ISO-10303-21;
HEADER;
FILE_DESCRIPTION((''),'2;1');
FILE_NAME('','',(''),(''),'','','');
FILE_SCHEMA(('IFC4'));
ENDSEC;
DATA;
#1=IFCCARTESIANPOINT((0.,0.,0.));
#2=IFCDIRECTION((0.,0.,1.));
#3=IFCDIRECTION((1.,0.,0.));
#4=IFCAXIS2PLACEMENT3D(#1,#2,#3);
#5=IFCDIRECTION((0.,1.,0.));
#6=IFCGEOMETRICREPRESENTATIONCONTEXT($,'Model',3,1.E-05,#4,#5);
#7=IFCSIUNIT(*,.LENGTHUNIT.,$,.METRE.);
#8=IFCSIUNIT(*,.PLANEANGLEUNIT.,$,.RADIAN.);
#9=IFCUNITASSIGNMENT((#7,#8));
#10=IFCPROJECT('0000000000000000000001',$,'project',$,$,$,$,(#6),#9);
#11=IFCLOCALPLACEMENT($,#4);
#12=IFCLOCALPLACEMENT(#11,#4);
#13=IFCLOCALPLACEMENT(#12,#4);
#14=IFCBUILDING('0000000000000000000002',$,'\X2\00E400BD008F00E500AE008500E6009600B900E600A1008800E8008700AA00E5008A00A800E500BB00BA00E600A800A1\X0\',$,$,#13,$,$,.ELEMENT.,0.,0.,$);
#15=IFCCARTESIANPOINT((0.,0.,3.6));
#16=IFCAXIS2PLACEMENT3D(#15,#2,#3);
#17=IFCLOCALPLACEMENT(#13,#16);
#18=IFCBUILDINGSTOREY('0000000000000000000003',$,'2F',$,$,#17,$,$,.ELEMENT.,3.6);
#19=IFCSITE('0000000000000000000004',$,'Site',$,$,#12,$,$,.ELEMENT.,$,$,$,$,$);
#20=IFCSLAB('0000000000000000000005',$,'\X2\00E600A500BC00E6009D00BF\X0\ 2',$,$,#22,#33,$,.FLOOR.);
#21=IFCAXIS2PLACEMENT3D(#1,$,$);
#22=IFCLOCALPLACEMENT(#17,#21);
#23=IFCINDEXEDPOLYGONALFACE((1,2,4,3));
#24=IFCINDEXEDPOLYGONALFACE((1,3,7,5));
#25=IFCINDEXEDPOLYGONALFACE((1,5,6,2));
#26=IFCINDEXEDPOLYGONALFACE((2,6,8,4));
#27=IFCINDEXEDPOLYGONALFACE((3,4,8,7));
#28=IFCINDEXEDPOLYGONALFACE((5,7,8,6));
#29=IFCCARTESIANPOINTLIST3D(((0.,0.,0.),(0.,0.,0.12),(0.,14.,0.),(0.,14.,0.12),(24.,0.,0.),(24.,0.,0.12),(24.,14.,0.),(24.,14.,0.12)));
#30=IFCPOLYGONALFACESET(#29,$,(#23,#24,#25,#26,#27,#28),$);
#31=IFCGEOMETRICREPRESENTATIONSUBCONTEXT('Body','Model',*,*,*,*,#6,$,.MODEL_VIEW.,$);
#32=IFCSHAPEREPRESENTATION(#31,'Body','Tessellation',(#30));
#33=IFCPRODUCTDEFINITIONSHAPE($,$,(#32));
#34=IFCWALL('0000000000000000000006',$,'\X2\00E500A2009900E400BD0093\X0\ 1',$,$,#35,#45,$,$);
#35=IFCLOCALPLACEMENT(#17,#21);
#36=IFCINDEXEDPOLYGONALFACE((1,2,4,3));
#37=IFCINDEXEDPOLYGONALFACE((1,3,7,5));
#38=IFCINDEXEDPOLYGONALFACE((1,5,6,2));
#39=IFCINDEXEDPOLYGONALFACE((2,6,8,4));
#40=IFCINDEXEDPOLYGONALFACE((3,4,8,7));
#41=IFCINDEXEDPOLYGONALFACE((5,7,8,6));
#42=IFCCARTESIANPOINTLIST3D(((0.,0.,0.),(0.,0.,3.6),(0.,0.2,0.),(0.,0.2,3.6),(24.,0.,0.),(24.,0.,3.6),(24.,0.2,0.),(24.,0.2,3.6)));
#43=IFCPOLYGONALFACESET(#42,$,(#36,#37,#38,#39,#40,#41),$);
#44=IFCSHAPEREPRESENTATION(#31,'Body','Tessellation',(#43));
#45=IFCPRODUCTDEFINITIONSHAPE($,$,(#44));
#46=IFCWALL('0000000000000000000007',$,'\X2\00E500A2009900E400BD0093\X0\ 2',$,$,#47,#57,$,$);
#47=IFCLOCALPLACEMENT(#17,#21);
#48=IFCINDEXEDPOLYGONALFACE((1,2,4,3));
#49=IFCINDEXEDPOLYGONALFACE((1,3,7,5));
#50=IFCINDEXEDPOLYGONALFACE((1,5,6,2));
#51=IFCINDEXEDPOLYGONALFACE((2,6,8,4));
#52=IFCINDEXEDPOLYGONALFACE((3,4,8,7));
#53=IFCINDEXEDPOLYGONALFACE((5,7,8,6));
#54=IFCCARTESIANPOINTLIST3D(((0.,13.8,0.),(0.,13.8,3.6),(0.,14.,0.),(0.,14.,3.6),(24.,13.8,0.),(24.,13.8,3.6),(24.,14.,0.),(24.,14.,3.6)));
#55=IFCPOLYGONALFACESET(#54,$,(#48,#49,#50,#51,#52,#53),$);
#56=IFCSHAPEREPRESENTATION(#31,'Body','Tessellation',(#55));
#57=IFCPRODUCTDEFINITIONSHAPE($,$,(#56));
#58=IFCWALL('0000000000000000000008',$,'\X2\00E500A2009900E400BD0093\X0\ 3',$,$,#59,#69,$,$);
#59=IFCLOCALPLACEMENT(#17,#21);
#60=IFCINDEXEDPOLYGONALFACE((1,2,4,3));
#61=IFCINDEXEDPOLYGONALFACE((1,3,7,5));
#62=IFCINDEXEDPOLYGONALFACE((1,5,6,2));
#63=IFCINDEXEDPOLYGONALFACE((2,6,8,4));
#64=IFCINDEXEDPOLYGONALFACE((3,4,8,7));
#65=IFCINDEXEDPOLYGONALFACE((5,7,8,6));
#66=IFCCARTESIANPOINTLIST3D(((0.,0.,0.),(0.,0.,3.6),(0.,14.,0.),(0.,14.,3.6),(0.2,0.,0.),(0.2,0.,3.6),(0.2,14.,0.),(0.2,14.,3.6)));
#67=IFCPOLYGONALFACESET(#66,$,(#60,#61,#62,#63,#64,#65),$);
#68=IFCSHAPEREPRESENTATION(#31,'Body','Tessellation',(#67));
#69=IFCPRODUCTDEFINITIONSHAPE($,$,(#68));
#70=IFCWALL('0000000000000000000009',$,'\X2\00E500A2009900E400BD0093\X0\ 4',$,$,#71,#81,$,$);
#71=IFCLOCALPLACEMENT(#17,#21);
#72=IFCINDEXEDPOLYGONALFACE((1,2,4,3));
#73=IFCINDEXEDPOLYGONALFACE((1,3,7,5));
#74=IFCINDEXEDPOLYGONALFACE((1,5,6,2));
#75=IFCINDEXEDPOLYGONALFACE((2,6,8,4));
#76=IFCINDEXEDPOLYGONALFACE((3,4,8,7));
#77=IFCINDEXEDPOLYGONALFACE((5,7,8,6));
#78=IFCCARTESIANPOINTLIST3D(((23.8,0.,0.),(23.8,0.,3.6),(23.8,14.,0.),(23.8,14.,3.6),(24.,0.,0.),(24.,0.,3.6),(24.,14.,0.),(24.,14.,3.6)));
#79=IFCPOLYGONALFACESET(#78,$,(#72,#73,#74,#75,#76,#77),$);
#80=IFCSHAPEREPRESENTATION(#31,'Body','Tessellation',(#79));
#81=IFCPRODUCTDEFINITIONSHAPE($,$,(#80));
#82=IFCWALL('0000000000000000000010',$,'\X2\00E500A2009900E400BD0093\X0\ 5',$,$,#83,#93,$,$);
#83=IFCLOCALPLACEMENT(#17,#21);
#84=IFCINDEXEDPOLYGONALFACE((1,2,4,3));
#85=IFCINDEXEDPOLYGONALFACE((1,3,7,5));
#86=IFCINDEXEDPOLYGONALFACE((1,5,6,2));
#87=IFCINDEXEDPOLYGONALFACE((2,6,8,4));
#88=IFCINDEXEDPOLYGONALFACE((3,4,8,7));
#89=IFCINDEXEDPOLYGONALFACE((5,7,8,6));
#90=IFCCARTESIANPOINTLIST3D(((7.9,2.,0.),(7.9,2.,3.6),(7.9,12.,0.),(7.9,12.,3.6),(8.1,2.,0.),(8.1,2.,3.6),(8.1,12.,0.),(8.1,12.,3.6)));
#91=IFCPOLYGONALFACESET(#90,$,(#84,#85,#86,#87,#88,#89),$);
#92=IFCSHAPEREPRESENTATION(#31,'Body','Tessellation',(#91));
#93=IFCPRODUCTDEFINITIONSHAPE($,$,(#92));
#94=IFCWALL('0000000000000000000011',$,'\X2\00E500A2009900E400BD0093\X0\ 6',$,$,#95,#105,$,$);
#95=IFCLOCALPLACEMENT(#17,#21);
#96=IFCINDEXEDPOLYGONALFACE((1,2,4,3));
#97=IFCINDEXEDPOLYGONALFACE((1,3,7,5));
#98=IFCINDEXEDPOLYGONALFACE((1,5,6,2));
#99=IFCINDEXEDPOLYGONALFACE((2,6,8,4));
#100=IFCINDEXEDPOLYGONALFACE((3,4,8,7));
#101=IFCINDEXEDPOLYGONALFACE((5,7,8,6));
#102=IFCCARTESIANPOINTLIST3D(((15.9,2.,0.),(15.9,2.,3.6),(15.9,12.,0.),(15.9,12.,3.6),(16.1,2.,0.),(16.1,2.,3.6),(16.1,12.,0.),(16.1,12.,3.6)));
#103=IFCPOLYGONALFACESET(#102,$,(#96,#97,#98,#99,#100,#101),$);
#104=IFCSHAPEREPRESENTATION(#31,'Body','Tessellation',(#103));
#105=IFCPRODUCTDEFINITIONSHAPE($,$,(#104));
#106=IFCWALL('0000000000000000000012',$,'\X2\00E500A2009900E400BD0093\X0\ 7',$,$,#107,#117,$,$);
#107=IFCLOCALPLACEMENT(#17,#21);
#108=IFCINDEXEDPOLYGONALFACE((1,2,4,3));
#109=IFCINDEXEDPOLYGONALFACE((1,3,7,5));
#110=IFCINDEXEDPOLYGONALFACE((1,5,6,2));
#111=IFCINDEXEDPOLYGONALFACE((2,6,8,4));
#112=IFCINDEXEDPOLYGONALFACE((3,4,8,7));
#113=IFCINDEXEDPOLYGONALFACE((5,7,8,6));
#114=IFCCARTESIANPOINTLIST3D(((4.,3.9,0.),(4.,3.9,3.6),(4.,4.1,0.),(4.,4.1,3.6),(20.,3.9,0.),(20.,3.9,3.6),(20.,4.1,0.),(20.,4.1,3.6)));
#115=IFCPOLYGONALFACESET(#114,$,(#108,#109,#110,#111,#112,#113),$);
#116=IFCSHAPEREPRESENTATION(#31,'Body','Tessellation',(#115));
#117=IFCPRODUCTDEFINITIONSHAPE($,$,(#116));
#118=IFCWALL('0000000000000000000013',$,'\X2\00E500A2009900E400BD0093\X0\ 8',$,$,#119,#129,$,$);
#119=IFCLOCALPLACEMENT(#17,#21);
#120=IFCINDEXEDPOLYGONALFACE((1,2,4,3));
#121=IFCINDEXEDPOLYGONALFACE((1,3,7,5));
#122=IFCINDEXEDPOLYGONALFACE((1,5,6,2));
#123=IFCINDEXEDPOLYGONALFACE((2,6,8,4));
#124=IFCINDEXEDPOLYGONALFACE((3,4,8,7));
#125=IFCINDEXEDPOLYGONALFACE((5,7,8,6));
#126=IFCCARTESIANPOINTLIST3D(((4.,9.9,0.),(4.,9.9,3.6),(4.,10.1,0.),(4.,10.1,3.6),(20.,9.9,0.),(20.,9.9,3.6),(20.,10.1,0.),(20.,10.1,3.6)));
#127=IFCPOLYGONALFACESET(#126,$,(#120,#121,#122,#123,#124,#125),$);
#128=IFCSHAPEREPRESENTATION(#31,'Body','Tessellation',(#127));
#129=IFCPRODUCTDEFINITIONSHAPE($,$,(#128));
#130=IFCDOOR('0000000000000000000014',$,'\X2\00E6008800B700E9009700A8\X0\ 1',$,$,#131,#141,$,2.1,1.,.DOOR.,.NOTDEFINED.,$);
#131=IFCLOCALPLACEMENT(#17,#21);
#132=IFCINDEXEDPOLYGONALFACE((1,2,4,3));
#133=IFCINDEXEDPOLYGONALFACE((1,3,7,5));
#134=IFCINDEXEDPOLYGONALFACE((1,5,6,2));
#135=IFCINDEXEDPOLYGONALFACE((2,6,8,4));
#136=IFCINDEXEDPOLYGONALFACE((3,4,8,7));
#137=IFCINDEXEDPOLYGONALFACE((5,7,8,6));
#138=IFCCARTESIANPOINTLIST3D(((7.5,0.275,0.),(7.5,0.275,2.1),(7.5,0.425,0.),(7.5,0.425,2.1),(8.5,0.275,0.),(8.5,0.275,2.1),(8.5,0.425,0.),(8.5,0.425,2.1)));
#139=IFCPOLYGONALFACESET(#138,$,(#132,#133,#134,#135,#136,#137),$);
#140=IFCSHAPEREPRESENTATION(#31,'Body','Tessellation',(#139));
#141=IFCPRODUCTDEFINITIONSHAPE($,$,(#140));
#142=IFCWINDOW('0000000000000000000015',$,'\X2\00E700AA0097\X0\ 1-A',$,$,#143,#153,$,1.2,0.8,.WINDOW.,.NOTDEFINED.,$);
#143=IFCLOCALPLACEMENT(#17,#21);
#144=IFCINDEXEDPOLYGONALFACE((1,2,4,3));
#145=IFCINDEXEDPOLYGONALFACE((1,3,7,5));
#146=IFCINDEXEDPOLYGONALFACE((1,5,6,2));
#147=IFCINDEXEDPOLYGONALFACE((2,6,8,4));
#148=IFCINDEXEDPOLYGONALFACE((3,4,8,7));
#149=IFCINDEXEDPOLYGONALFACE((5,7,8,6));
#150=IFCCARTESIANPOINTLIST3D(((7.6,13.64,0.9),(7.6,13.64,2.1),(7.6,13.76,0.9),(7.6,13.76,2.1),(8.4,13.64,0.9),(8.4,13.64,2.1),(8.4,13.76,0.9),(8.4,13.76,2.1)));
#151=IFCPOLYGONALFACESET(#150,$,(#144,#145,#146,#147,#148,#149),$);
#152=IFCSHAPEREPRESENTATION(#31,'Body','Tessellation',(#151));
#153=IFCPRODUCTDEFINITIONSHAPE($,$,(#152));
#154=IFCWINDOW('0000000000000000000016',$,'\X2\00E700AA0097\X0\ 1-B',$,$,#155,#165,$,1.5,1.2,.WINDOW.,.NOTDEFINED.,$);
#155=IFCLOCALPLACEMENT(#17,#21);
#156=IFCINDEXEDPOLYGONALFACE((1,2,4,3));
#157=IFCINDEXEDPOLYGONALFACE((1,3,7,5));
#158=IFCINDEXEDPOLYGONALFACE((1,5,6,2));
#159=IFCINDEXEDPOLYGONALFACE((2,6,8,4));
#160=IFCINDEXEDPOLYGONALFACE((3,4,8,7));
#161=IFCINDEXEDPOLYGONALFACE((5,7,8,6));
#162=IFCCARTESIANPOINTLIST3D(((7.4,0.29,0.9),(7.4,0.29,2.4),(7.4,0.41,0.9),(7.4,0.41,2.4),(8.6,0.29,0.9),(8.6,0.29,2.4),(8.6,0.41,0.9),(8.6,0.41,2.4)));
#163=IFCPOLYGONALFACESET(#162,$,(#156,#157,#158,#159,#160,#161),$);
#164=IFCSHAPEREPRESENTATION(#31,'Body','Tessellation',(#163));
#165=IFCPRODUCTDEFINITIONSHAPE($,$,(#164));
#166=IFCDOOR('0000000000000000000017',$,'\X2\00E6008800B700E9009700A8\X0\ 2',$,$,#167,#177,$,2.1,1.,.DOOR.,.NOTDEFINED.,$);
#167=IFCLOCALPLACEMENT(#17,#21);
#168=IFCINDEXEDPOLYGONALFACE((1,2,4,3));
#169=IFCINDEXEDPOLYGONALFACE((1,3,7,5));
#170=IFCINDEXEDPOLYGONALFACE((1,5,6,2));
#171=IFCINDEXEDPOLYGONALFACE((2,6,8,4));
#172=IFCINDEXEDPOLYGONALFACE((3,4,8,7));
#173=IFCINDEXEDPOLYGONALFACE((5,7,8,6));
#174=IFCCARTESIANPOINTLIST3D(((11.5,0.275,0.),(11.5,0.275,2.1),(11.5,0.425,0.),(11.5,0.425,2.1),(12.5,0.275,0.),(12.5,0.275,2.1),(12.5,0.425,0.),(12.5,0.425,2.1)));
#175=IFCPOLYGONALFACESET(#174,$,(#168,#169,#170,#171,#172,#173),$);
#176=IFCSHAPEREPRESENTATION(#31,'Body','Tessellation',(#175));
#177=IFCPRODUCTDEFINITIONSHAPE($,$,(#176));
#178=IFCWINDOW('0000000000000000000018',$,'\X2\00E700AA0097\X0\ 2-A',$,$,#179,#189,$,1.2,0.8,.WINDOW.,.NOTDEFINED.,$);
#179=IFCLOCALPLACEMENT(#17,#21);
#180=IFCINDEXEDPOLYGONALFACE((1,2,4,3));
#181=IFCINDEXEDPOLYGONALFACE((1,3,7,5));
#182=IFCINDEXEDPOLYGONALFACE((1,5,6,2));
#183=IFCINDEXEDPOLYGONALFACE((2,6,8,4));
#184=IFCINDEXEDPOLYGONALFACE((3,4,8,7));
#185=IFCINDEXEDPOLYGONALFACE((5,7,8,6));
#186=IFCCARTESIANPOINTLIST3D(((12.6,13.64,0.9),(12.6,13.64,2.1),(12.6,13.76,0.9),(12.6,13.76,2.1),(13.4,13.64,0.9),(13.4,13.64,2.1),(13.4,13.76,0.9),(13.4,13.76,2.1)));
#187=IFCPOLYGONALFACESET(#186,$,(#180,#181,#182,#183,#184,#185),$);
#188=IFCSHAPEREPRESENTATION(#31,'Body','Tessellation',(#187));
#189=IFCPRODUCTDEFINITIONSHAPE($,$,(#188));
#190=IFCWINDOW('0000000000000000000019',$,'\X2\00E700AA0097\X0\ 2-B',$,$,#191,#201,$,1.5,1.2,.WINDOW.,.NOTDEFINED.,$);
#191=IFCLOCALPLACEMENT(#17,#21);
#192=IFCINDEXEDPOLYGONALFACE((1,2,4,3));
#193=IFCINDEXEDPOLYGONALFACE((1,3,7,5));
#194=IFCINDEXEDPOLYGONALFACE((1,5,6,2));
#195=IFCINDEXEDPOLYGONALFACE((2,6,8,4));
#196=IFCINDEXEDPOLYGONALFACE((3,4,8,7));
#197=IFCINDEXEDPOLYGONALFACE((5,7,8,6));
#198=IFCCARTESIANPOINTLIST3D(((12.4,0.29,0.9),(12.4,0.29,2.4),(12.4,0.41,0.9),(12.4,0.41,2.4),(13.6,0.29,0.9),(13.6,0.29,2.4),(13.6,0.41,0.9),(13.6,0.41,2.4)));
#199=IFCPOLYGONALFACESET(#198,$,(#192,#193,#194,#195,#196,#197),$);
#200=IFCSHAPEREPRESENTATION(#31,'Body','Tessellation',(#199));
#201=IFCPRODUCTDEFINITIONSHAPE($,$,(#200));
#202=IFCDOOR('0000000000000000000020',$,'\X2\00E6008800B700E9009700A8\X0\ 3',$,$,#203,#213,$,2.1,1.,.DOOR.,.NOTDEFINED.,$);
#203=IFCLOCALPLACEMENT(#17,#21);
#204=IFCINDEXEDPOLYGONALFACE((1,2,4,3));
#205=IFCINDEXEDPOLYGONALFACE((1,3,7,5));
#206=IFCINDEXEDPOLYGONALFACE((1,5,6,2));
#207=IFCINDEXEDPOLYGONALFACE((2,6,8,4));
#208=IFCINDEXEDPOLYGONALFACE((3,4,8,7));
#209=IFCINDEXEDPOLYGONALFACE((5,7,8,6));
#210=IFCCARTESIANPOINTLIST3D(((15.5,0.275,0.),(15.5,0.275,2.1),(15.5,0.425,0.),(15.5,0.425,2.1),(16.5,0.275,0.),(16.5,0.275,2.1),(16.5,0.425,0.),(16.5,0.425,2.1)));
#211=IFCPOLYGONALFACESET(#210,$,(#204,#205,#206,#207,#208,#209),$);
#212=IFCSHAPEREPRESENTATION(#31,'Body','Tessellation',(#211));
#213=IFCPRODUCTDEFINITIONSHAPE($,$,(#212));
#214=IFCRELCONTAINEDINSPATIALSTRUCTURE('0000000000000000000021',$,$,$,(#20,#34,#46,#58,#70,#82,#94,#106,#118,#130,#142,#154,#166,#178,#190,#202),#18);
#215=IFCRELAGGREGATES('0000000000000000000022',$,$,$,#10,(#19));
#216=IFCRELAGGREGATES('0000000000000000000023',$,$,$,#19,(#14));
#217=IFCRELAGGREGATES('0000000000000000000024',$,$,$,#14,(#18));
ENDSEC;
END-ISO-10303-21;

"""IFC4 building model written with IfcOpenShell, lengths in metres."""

from ifc_helpers import new_model, si_unit, direction, frame, frame_2d, origin_with_axes, place, context, subcontext, project, spatial, rectangle, extrude, element, save


model = new_model("IFC4")

# Units and contexts
model_context = context("Model", 3, precision=1e-05, world=origin_with_axes(), true_north=direction((0.0, 1.0, 0.0)))
body_context = subcontext(model_context, "Body", "Model", "MODEL_VIEW")
ifc_project = project(units=[si_unit("LENGTHUNIT", "METRE"), si_unit("PLANEANGLEUNIT", "RADIAN")], contexts=[model_context])

# Site, building, storey
placement = place(None, origin_with_axes())
site_placement = place(placement, origin_with_axes())
site = spatial("IfcSite", under=ifc_project, at=site_placement, Name="Site", CompositionType="ELEMENT")
building_placement = place(site_placement, origin_with_axes())
building = spatial("IfcBuilding", under=site, at=building_placement, Name="ä½\u008få®\u0085æ\u0096¹æ¡\u0088è\u0087ªå\u008a¨å»ºæ¨¡", CompositionType="ELEMENT", ElevationOfRefHeight=0.0, ElevationOfTerrain=0.0)
storey_placement = place(building_placement, frame((0.0, 0.0, 3.6), z_axis=(0.0, 0.0, 1.0), x_axis=(1.0, 0.0, 0.0)))
storey = spatial("IfcBuildingStorey", under=building, at=storey_placement, Name="2F", CompositionType="ELEMENT", Elevation=3.6)

# Slab
slab_placement = place(storey_placement, frame((12.0, 7.0, 0.0), z_axis=(0.0, 0.0, 1.0), x_axis=(1.0, 0.0, 0.0)))
element("IfcSlab", 1, at=slab_placement, inside=storey, Name="æ¥¼æ\u009d¿ 2", PredefinedType="FLOOR", context=body_context, shape_type="SweptSolid", body=[
    extrude(rectangle(XDim=24.0, YDim=14.0, at=frame_2d((0.0, 0.0), x_axis=(1.0, 0.0, 0.0))), frame((0.0, 0.0, 0.0), z_axis=(0.0, 0.0, 1.0)), (0.0, 0.0, 1.0), 0.12),
])

# Walls
for number, where, z_axis, x_axis, name in (
    (2, (12.0, 0.1, 0.0), (0.0, 0.0, 1.0), (1.0, 0.0, 0.0), "å¢\u0099ä½\u0093 1"),
    (3, (12.0, 13.9, 0.0), (0.0, 0.0, 1.0), (1.0, 0.0, 0.0), "å¢\u0099ä½\u0093 2"),
):
    element("IfcWall", number, at=place(storey_placement, frame(where, z_axis=z_axis, x_axis=x_axis)), inside=storey, Name=name, context=body_context, shape_type="SweptSolid", body=[
        extrude(rectangle(XDim=24.0, YDim=0.2, at=frame_2d((0.0, 0.0), x_axis=(1.0, 0.0, 0.0))), frame((0.0, 0.0, 0.0), z_axis=(0.0, 0.0, 1.0)), (0.0, 0.0, 1.0), 3.6),
    ])
for number, where, z_axis, x_axis, name in (
    (4, (0.1, 7.0, 0.0), (0.0, 0.0, 1.0), (0.0, 1.0, 0.0), "å¢\u0099ä½\u0093 3"),
    (5, (23.9, 7.0, 0.0), (0.0, 0.0, 1.0), (0.0, 1.0, 0.0), "å¢\u0099ä½\u0093 4"),
):
    element("IfcWall", number, at=place(storey_placement, frame(where, z_axis=z_axis, x_axis=x_axis)), inside=storey, Name=name, context=body_context, shape_type="SweptSolid", body=[
        extrude(rectangle(XDim=14.0, YDim=0.2, at=frame_2d((0.0, 0.0), x_axis=(1.0, 0.0, 0.0))), frame((0.0, 0.0, 0.0), z_axis=(0.0, 0.0, 1.0)), (0.0, 0.0, 1.0), 3.6),
    ])
for number, where, z_axis, x_axis, name in (
    (6, (8.0, 7.0, 0.0), (0.0, 0.0, 1.0), (0.0, 1.0, 0.0), "å¢\u0099ä½\u0093 5"),
    (7, (16.0, 7.0, 0.0), (0.0, 0.0, 1.0), (0.0, 1.0, 0.0), "å¢\u0099ä½\u0093 6"),
):
    element("IfcWall", number, at=place(storey_placement, frame(where, z_axis=z_axis, x_axis=x_axis)), inside=storey, Name=name, context=body_context, shape_type="SweptSolid", body=[
        extrude(rectangle(XDim=10.0, YDim=0.2, at=frame_2d((0.0, 0.0), x_axis=(1.0, 0.0, 0.0))), frame((0.0, 0.0, 0.0), z_axis=(0.0, 0.0, 1.0)), (0.0, 0.0, 1.0), 3.6),
    ])
for number, where, z_axis, x_axis, name in (
    (8, (12.0, 4.0, 0.0), (0.0, 0.0, 1.0), (1.0, 0.0, 0.0), "å¢\u0099ä½\u0093 7"),
    (9, (12.0, 10.0, 0.0), (0.0, 0.0, 1.0), (1.0, 0.0, 0.0), "å¢\u0099ä½\u0093 8"),
):
    element("IfcWall", number, at=place(storey_placement, frame(where, z_axis=z_axis, x_axis=x_axis)), inside=storey, Name=name, context=body_context, shape_type="SweptSolid", body=[
        extrude(rectangle(XDim=16.0, YDim=0.2, at=frame_2d((0.0, 0.0), x_axis=(1.0, 0.0, 0.0))), frame((0.0, 0.0, 0.0), z_axis=(0.0, 0.0, 1.0)), (0.0, 0.0, 1.0), 3.6),
    ])

# Door
door_1_placement = place(storey_placement, frame((8.0, 0.35, 0.0), z_axis=(0.0, 0.0, 1.0), x_axis=(1.0, 0.0, 0.0)))
element("IfcDoor", 10, at=door_1_placement, inside=storey, Name="æ\u0088·é\u0097¨ 1", OperationType="NOTDEFINED", OverallHeight=2.1, OverallWidth=1.0, PredefinedType="DOOR", context=body_context, shape_type="SweptSolid", body=[
    extrude(rectangle(XDim=1.0, YDim=0.15, at=frame_2d((0.0, 0.0), x_axis=(1.0, 0.0, 0.0))), frame((0.0, 0.0, 0.0), z_axis=(0.0, 0.0, 1.0)), (0.0, 0.0, 1.0), 2.1),
])

# Windows
window_1_placement = place(storey_placement, frame((8.0, 13.7, 0.9), z_axis=(0.0, 0.0, 1.0), x_axis=(1.0, 0.0, 0.0)))
element("IfcWindow", 11, at=window_1_placement, inside=storey, Name="çª\u0097 1-A", OverallHeight=1.2, OverallWidth=0.8, PartitioningType="NOTDEFINED", PredefinedType="WINDOW", context=body_context, shape_type="SweptSolid", body=[
    extrude(rectangle(XDim=0.8, YDim=0.12, at=frame_2d((0.0, 0.0), x_axis=(1.0, 0.0, 0.0))), frame((0.0, 0.0, 0.0), z_axis=(0.0, 0.0, 1.0)), (0.0, 0.0, 1.0), 1.2),
])
window_2_placement = place(storey_placement, frame((8.0, 0.35, 0.9), z_axis=(0.0, 0.0, 1.0), x_axis=(1.0, 0.0, 0.0)))
element("IfcWindow", 12, at=window_2_placement, inside=storey, Name="çª\u0097 1-B", OverallHeight=1.5, OverallWidth=1.2, PartitioningType="NOTDEFINED", PredefinedType="WINDOW", context=body_context, shape_type="SweptSolid", body=[
    extrude(rectangle(XDim=1.2, YDim=0.12, at=frame_2d((0.0, 0.0), x_axis=(1.0, 0.0, 0.0))), frame((0.0, 0.0, 0.0), z_axis=(0.0, 0.0, 1.0)), (0.0, 0.0, 1.0), 1.5),
])

# Door
door_2_placement = place(storey_placement, frame((12.0, 0.35, 0.0), z_axis=(0.0, 0.0, 1.0), x_axis=(1.0, 0.0, 0.0)))
element("IfcDoor", 13, at=door_2_placement, inside=storey, Name="æ\u0088·é\u0097¨ 2", OperationType="NOTDEFINED", OverallHeight=2.1, OverallWidth=1.0, PredefinedType="DOOR", context=body_context, shape_type="SweptSolid", body=[
    extrude(rectangle(XDim=1.0, YDim=0.15, at=frame_2d((0.0, 0.0), x_axis=(1.0, 0.0, 0.0))), frame((0.0, 0.0, 0.0), z_axis=(0.0, 0.0, 1.0)), (0.0, 0.0, 1.0), 2.1),
])

# Windows
window_3_placement = place(storey_placement, frame((13.0, 13.7, 0.9), z_axis=(0.0, 0.0, 1.0), x_axis=(1.0, 0.0, 0.0)))
element("IfcWindow", 14, at=window_3_placement, inside=storey, Name="çª\u0097 2-A", OverallHeight=1.2, OverallWidth=0.8, PartitioningType="NOTDEFINED", PredefinedType="WINDOW", context=body_context, shape_type="SweptSolid", body=[
    extrude(rectangle(XDim=0.8, YDim=0.12, at=frame_2d((0.0, 0.0), x_axis=(1.0, 0.0, 0.0))), frame((0.0, 0.0, 0.0), z_axis=(0.0, 0.0, 1.0)), (0.0, 0.0, 1.0), 1.2),
])
window_4_placement = place(storey_placement, frame((13.0, 0.35, 0.9), z_axis=(0.0, 0.0, 1.0), x_axis=(1.0, 0.0, 0.0)))
element("IfcWindow", 15, at=window_4_placement, inside=storey, Name="çª\u0097 2-B", OverallHeight=1.5, OverallWidth=1.2, PartitioningType="NOTDEFINED", PredefinedType="WINDOW", context=body_context, shape_type="SweptSolid", body=[
    extrude(rectangle(XDim=1.2, YDim=0.12, at=frame_2d((0.0, 0.0), x_axis=(1.0, 0.0, 0.0))), frame((0.0, 0.0, 0.0), z_axis=(0.0, 0.0, 1.0)), (0.0, 0.0, 1.0), 1.5),
])

# Door
door_3_placement = place(storey_placement, frame((16.0, 0.35, 0.0), z_axis=(0.0, 0.0, 1.0), x_axis=(1.0, 0.0, 0.0)))
element("IfcDoor", 16, at=door_3_placement, inside=storey, Name="æ\u0088·é\u0097¨ 3", OperationType="NOTDEFINED", OverallHeight=2.1, OverallWidth=1.0, PredefinedType="DOOR", context=body_context, shape_type="SweptSolid", body=[
    extrude(rectangle(XDim=1.0, YDim=0.15, at=frame_2d((0.0, 0.0), x_axis=(1.0, 0.0, 0.0))), frame((0.0, 0.0, 0.0), z_axis=(0.0, 0.0, 1.0)), (0.0, 0.0, 1.0), 2.1),
])

save(model, "model.ifc")
